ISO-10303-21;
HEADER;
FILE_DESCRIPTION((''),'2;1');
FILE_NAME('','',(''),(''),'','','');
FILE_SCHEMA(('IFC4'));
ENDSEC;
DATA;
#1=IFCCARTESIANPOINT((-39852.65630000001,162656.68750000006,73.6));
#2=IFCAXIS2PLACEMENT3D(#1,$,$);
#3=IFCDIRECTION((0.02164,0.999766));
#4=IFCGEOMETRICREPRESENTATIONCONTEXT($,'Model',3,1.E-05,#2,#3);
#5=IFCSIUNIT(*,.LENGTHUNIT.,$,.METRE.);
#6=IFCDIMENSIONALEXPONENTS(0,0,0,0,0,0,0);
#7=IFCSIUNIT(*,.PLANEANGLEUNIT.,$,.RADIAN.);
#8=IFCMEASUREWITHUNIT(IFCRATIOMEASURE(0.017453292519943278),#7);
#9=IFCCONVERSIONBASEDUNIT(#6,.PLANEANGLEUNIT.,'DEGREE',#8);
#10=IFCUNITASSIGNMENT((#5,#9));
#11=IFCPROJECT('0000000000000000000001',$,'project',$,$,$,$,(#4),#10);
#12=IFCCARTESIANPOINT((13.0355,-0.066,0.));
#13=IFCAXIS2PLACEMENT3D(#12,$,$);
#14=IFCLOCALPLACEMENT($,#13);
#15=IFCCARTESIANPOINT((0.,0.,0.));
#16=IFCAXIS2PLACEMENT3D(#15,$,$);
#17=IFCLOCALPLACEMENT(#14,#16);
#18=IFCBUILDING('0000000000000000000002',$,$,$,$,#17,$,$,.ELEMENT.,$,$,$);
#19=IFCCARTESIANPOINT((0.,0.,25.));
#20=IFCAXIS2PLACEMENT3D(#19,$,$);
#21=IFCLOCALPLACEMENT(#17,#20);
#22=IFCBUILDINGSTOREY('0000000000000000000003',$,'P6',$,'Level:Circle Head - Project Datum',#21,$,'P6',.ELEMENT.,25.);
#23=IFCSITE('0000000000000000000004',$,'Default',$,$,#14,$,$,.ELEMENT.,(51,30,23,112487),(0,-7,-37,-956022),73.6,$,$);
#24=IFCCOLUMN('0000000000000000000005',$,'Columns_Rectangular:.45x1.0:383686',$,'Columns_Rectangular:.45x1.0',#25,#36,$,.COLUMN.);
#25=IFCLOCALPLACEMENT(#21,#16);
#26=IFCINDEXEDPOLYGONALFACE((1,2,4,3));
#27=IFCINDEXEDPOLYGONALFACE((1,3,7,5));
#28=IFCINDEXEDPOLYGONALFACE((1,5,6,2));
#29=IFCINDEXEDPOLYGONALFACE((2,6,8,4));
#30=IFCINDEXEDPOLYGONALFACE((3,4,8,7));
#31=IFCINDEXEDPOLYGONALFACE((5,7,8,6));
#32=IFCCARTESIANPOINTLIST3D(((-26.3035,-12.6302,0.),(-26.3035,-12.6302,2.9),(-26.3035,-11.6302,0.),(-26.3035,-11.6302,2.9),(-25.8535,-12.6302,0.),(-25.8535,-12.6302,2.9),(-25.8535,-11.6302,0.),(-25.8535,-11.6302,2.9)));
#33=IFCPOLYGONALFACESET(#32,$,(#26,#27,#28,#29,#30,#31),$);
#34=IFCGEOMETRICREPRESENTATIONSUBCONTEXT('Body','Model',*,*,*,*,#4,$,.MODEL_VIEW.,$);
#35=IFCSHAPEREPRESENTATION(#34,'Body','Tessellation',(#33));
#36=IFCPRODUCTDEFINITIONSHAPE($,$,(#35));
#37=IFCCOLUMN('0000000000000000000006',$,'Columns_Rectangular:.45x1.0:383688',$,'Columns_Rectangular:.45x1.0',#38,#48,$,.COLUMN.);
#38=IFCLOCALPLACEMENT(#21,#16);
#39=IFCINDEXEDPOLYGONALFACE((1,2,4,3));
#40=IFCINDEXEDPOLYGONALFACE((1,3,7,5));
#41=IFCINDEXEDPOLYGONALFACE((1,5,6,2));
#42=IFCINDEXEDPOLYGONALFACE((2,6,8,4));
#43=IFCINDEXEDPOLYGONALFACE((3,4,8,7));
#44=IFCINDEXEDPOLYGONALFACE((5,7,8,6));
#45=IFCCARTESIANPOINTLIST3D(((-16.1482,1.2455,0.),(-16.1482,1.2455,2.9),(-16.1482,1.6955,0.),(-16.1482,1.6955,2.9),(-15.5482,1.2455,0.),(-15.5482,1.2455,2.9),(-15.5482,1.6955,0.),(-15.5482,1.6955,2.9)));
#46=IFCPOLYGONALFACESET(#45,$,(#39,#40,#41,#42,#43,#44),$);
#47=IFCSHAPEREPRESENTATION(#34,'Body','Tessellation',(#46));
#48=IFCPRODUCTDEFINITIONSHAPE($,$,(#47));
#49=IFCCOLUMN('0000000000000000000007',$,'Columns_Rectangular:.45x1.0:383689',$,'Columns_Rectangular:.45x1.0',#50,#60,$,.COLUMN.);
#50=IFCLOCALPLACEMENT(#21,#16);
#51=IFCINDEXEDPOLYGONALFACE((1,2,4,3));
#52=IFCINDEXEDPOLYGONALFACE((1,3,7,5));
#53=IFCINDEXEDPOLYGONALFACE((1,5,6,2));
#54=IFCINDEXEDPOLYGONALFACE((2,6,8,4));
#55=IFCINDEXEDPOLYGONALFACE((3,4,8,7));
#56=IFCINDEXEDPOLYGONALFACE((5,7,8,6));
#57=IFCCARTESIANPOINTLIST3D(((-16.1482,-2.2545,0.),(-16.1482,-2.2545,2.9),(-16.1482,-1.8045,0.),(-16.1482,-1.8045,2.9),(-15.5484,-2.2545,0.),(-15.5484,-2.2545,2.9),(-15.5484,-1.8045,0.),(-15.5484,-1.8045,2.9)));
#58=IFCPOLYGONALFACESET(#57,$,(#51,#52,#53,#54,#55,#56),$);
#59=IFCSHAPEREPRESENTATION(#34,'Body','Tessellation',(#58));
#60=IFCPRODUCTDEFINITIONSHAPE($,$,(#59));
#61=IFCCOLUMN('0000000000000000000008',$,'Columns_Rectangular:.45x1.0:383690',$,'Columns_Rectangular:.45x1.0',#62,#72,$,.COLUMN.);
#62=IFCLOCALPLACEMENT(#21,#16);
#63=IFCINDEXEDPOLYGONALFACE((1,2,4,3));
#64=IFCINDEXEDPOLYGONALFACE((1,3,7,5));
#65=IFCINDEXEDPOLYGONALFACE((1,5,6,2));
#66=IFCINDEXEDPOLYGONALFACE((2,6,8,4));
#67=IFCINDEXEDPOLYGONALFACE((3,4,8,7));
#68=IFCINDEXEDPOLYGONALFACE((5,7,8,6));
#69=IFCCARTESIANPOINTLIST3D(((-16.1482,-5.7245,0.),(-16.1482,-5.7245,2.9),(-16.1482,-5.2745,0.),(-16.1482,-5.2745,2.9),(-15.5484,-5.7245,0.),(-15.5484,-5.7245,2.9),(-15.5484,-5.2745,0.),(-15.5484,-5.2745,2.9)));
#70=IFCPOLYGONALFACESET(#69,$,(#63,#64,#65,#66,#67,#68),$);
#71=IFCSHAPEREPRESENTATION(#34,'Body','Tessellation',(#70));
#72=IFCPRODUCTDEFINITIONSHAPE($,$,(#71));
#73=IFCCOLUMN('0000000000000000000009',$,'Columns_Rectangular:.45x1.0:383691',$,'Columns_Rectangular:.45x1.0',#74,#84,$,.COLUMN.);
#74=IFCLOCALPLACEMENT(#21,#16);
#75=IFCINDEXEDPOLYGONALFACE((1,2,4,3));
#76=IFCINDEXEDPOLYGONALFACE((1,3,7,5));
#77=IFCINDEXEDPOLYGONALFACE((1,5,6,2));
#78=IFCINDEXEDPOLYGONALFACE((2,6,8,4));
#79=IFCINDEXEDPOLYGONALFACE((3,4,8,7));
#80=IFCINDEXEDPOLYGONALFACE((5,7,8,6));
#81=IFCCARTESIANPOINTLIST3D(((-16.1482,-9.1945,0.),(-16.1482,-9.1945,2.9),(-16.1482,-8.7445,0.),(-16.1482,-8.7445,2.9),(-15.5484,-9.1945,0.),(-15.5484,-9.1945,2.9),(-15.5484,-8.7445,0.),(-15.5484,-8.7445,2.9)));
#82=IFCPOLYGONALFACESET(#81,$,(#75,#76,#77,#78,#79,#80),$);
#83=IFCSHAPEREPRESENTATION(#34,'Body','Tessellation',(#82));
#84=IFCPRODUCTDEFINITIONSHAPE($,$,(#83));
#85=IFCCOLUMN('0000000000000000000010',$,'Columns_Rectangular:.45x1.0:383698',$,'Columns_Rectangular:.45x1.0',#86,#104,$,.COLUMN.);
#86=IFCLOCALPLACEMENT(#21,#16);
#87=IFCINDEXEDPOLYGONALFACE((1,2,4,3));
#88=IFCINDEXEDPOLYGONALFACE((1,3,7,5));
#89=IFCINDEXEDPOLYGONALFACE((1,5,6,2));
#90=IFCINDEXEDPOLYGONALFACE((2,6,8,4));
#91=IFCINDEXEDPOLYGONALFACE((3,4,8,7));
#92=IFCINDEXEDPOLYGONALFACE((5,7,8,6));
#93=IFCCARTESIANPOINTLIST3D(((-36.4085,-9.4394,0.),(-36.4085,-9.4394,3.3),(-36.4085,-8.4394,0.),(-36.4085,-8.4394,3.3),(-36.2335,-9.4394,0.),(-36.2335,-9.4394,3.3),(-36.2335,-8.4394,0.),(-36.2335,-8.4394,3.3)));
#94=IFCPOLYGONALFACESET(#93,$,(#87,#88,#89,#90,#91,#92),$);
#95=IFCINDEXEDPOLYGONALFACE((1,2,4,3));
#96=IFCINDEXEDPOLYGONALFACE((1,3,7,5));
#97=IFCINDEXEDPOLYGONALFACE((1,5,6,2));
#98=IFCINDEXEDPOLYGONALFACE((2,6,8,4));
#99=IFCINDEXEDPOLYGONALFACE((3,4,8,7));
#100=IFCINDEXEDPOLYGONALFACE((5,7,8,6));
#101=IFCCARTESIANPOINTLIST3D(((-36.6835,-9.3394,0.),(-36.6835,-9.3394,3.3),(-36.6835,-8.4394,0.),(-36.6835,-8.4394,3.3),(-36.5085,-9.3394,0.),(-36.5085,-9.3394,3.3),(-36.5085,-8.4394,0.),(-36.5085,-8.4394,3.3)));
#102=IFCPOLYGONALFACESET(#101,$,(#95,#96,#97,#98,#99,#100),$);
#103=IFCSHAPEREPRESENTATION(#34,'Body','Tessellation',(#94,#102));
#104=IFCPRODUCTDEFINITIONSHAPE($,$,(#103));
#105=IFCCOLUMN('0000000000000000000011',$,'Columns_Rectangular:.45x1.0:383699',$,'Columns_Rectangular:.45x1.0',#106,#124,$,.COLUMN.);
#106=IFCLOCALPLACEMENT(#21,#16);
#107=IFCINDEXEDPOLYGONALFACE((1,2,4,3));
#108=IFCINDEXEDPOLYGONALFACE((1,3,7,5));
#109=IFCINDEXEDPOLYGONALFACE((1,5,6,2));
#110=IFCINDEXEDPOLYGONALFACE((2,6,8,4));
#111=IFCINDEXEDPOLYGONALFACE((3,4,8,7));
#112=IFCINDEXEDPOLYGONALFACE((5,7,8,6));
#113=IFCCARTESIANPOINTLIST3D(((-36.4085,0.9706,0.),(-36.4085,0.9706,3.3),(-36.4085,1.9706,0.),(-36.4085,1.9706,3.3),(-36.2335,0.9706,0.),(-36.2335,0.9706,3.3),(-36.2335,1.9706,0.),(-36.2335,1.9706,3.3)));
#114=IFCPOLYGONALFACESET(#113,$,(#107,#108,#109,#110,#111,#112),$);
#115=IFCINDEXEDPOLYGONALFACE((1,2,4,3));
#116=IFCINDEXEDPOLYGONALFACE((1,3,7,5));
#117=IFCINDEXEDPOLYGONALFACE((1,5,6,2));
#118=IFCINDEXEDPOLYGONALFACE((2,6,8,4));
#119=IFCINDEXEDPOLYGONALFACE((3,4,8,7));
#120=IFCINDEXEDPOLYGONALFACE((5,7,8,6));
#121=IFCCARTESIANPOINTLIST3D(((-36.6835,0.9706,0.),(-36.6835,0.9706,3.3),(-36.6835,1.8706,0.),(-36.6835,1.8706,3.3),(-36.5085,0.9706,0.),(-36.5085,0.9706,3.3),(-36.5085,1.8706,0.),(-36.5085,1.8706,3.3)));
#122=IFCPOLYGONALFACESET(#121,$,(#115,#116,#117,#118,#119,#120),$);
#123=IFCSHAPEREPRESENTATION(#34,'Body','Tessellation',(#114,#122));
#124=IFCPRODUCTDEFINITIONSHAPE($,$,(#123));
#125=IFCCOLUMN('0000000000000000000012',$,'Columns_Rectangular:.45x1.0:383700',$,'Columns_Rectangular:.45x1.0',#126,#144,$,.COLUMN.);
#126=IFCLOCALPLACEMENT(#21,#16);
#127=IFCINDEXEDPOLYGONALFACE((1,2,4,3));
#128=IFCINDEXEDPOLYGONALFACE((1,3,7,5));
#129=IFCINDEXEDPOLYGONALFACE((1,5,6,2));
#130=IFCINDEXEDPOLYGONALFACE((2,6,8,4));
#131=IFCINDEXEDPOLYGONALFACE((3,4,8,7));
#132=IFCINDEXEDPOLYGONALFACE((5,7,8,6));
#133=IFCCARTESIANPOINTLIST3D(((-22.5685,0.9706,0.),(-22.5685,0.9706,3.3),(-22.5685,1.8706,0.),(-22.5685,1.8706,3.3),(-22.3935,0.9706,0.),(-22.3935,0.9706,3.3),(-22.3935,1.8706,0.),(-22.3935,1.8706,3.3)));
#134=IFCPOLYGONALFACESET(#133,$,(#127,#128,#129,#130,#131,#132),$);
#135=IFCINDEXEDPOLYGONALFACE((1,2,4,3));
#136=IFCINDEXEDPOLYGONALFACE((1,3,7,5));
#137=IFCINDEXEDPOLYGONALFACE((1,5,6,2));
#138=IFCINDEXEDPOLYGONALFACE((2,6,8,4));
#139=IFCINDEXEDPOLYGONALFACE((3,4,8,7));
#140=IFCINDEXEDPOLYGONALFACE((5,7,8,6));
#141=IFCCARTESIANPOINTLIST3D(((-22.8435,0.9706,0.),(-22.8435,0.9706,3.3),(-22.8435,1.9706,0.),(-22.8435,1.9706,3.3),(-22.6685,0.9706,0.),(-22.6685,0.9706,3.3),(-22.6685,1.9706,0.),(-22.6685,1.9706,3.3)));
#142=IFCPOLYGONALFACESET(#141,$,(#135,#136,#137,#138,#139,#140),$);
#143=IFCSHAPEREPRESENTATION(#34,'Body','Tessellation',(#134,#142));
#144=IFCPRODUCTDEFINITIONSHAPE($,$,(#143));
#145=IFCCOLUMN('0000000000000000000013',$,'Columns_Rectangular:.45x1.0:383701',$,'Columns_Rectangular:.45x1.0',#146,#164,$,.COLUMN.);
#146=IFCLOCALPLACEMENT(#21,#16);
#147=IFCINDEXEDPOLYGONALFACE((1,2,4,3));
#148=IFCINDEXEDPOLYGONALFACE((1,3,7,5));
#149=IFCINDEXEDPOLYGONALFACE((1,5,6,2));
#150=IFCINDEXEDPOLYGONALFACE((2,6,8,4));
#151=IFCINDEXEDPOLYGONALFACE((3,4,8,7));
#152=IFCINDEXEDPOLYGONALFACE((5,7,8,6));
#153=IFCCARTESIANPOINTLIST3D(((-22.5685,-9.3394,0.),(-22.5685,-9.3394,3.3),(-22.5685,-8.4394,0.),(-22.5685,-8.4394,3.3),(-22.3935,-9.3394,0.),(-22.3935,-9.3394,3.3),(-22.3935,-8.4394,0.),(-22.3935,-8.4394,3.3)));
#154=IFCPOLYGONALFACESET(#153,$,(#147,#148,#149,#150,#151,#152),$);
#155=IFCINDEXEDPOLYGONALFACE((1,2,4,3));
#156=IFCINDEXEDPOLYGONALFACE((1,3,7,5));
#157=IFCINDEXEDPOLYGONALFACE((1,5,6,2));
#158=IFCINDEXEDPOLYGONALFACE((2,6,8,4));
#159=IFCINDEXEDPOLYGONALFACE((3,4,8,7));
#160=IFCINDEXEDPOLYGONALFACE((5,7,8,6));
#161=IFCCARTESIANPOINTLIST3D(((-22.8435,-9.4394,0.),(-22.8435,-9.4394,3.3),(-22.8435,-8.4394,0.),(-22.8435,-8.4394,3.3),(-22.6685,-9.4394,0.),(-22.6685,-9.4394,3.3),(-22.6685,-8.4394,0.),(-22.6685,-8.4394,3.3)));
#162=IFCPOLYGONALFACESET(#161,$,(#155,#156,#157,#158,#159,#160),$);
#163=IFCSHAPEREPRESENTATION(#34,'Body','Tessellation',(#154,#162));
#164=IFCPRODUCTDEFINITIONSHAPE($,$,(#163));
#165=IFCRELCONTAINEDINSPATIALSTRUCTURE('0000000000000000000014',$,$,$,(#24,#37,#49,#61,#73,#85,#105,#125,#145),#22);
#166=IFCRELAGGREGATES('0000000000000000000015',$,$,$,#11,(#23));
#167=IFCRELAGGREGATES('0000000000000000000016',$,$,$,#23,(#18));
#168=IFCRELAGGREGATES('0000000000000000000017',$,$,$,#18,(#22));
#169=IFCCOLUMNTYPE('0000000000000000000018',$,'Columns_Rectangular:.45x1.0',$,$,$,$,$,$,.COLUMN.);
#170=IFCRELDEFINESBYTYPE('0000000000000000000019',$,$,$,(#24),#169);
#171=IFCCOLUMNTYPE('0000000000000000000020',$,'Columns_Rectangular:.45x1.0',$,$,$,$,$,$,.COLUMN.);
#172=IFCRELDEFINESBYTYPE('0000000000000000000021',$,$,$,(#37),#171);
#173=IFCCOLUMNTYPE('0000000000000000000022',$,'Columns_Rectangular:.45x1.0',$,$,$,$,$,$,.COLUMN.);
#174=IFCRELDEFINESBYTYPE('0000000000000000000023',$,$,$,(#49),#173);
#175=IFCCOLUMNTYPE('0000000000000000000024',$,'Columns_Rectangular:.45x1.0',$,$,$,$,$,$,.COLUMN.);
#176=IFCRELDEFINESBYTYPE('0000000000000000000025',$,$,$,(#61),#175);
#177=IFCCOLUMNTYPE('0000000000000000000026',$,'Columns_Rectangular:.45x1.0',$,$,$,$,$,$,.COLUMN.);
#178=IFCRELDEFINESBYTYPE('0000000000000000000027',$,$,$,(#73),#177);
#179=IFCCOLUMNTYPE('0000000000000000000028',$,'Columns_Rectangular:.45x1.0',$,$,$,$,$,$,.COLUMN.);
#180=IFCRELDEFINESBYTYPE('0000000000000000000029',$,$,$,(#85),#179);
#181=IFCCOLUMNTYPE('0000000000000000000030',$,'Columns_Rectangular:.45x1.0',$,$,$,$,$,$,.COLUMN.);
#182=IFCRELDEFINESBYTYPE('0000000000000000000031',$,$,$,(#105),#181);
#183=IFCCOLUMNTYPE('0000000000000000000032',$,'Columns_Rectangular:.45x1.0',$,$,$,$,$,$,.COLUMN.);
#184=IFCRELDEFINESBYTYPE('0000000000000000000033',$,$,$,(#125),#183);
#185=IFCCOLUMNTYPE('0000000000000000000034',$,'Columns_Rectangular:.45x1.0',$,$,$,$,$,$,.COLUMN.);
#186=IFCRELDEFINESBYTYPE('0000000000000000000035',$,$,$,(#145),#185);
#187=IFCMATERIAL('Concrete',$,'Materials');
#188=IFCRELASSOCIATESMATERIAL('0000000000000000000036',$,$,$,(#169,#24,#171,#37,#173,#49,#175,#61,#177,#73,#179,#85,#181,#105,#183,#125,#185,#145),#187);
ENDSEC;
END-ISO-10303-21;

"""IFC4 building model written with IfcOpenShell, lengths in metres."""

from ifc_helpers import new_model, entity, si_unit, converted_unit, direction, frame, origin, place, context, subcontext, project, spatial, indexed_curve, outline, extrude, source, transform, mapped, material, type_object, type_shapes, element, save


model = new_model("IFC4")

# Units and contexts
model_context = context("Model", 3, precision=1e-05, world=frame((-39852.65630000001, 162656.68750000006, 73.6)), true_north=direction((0.02164, 0.999766)))
body_context = subcontext(model_context, "Body", "Model", "MODEL_VIEW")
ifc_project = project(units=[si_unit("LENGTHUNIT", "METRE"), converted_unit("PLANEANGLEUNIT", "DEGREE", entity("IfcRatioMeasure", 0.017453292519943278), si_unit("PLANEANGLEUNIT", "RADIAN"), dimensions=[0, 0, 0, 0, 0, 0, 0])], contexts=[model_context])

# Site, building, storey
site_placement = place(None, frame((13.0355, -0.066, 0.0)))
site = spatial("IfcSite", under=ifc_project, at=site_placement, Name="Default", CompositionType="ELEMENT", RefLatitude=(51, 30, 23, 112487), RefLongitude=(0, -7, -37, -956022), RefElevation=73.6)
building_placement = place(site_placement, origin())
building = spatial("IfcBuilding", under=site, at=building_placement, CompositionType="ELEMENT")
storey_placement = place(building_placement, frame((0.0, 0.0, 25.0)))
storey = spatial("IfcBuildingStorey", under=building, at=storey_placement, Name="P6", ObjectType="Level:Circle Head - Project Datum", LongName="P6", CompositionType="ELEMENT", Elevation=25.0)

# Columns
ifc_material = material(Name="Concrete", Category="Materials")
column_type_1 = type_object("IfcColumnType", Name="Columns_Rectangular:.45x1.0", PredefinedType="COLUMN", material=ifc_material)
shared_shape_1 = source(origin(), body_context, "Body", "SweptSolid", [
    extrude(outline(indexed_curve([(-0.5, -0.225), (0.5, -0.225), (0.5, 0.225), (-0.5, 0.225), (-0.5, -0.225)], self_intersect=False)), frame((-26.0785, -12.1302, 25.0), z_axis=(0.0, 0.0, 1.0), x_axis=(0.000011, 1.0, 0.0)), (0.0, 0.0, 1.0), 2.9),
])
type_shapes(column_type_1, [shared_shape_1])
column_1_placement = place(storey_placement, frame((0.0, 0.0, -25.0)))
element("IfcColumn", 1, at=column_1_placement, inside=storey, type_object=column_type_1, material=ifc_material, Name="Columns_Rectangular:.45x1.0:383686", ObjectType="Columns_Rectangular:.45x1.0", PredefinedType="COLUMN", context=body_context, shape_type="MappedRepresentation", body=[
    mapped(shared_shape_1, transform((0.0, 0.0, 0.0), scale=1.0)),
])
column_type_2 = type_object("IfcColumnType", Name="Columns_Rectangular:.45x1.0", PredefinedType="COLUMN", material=ifc_material)
shared_shape_2 = source(origin(), body_context, "Body", "SweptSolid", [
    extrude(outline(indexed_curve([(-0.225, -0.3), (0.225, -0.3), (0.225, 0.3), (-0.225, 0.3), (-0.225, -0.3)], self_intersect=False)), frame((-15.8482, 1.4705, 25.0), z_axis=(0.0, 0.0, 1.0), x_axis=(0.0, -1.0, 0.0)), (0.0, 0.0, 1.0), 2.9),
])
type_shapes(column_type_2, [shared_shape_2])
column_2_placement = place(storey_placement, frame((0.0, 0.0, -25.0)))
element("IfcColumn", 2, at=column_2_placement, inside=storey, type_object=column_type_2, material=ifc_material, Name="Columns_Rectangular:.45x1.0:383688", ObjectType="Columns_Rectangular:.45x1.0", PredefinedType="COLUMN", context=body_context, shape_type="MappedRepresentation", body=[
    mapped(shared_shape_2, transform((0.0, 0.0, 0.0), scale=1.0)),
])
column_type_3 = type_object("IfcColumnType", Name="Columns_Rectangular:.45x1.0", PredefinedType="COLUMN", material=ifc_material)
shared_shape_3 = source(origin(), body_context, "Body", "SweptSolid", [
    extrude(outline(indexed_curve([(-0.225, -0.2999), (0.225, -0.2999), (0.225, 0.2999), (-0.225, 0.2999), (-0.225, -0.2999)], self_intersect=False)), frame((-15.8483, -2.0295, 25.0), z_axis=(0.0, 0.0, 1.0), x_axis=(0.0, -1.0, 0.0)), (0.0, 0.0, 1.0), 2.9),
])
type_shapes(column_type_3, [shared_shape_3])
column_3_placement = place(storey_placement, frame((0.0, 0.0, -25.0)))
element("IfcColumn", 3, at=column_3_placement, inside=storey, type_object=column_type_3, material=ifc_material, Name="Columns_Rectangular:.45x1.0:383689", ObjectType="Columns_Rectangular:.45x1.0", PredefinedType="COLUMN", context=body_context, shape_type="MappedRepresentation", body=[
    mapped(shared_shape_3, transform((0.0, 0.0, 0.0), scale=1.0)),
])
column_type_4 = type_object("IfcColumnType", Name="Columns_Rectangular:.45x1.0", PredefinedType="COLUMN", material=ifc_material)
shared_shape_4 = source(origin(), body_context, "Body", "SweptSolid", [
    extrude(outline(indexed_curve([(-0.225, -0.2999), (0.225, -0.2999), (0.225, 0.2999), (-0.225, 0.2999), (-0.225, -0.2999)], self_intersect=False)), frame((-15.8483, -5.4995, 25.0), z_axis=(0.0, 0.0, 1.0), x_axis=(0.0, -1.0, 0.0)), (0.0, 0.0, 1.0), 2.9),
])
type_shapes(column_type_4, [shared_shape_4])
column_4_placement = place(storey_placement, frame((0.0, 0.0, -25.0)))
element("IfcColumn", 4, at=column_4_placement, inside=storey, type_object=column_type_4, material=ifc_material, Name="Columns_Rectangular:.45x1.0:383690", ObjectType="Columns_Rectangular:.45x1.0", PredefinedType="COLUMN", context=body_context, shape_type="MappedRepresentation", body=[
    mapped(shared_shape_4, transform((0.0, 0.0, 0.0), scale=1.0)),
])
column_type_5 = type_object("IfcColumnType", Name="Columns_Rectangular:.45x1.0", PredefinedType="COLUMN", material=ifc_material)
shared_shape_5 = source(origin(), body_context, "Body", "SweptSolid", [
    extrude(outline(indexed_curve([(-0.225, -0.2999), (0.225, -0.2999), (0.225, 0.2999), (-0.225, 0.2999), (-0.225, -0.2999)], self_intersect=False)), frame((-15.8483, -8.9695, 25.0), z_axis=(0.0, 0.0, 1.0), x_axis=(0.0, -1.0, 0.0)), (0.0, 0.0, 1.0), 2.9),
])
type_shapes(column_type_5, [shared_shape_5])
column_5_placement = place(storey_placement, frame((0.0, 0.0, -25.0)))
element("IfcColumn", 5, at=column_5_placement, inside=storey, type_object=column_type_5, material=ifc_material, Name="Columns_Rectangular:.45x1.0:383691", ObjectType="Columns_Rectangular:.45x1.0", PredefinedType="COLUMN", context=body_context, shape_type="MappedRepresentation", body=[
    mapped(shared_shape_5, transform((0.0, 0.0, 0.0), scale=1.0)),
])
column_type_6 = type_object("IfcColumnType", Name="Columns_Rectangular:.45x1.0", PredefinedType="COLUMN", material=ifc_material)
shared_shape_6 = source(origin(), body_context, "Body", "SweptSolid", [
    extrude(outline(indexed_curve([(-0.5, -0.0875), (0.5, -0.0875), (0.5, 0.0875), (-0.5, 0.0875), (-0.5, -0.0875)], self_intersect=False)), frame((-36.321, -8.9394, 25.0), z_axis=(0.0, 0.0, 1.0), x_axis=(0.0, -1.0, 0.0)), (0.0, 0.0, 1.0), 3.3),
    extrude(outline(indexed_curve([(-0.45, -0.0875), (0.45, -0.0875), (0.45, 0.0875), (-0.45, 0.0875), (-0.45, -0.0875)], self_intersect=False)), frame((-36.596, -8.8894, 25.0), z_axis=(0.0, 0.0, 1.0), x_axis=(0.0, -1.0, 0.0)), (0.0, 0.0, 1.0), 3.3),
])
type_shapes(column_type_6, [shared_shape_6])
column_6_placement = place(storey_placement, frame((0.0, 0.0, -25.0)))
element("IfcColumn", 6, at=column_6_placement, inside=storey, type_object=column_type_6, material=ifc_material, Name="Columns_Rectangular:.45x1.0:383698", ObjectType="Columns_Rectangular:.45x1.0", PredefinedType="COLUMN", context=body_context, shape_type="MappedRepresentation", body=[
    mapped(shared_shape_6, transform((0.0, 0.0, 0.0), scale=1.0)),
])
column_type_7 = type_object("IfcColumnType", Name="Columns_Rectangular:.45x1.0", PredefinedType="COLUMN", material=ifc_material)
shared_shape_7 = source(origin(), body_context, "Body", "SweptSolid", [
    extrude(outline(indexed_curve([(-0.5, -0.0875), (0.5, -0.0875), (0.5, 0.0875), (-0.5, 0.0875), (-0.5, -0.0875)], self_intersect=False)), frame((-36.321, 1.4706, 25.0), z_axis=(0.0, 0.0, 1.0), x_axis=(0.0, -1.0, 0.0)), (0.0, 0.0, 1.0), 3.3),
    extrude(outline(indexed_curve([(-0.45, -0.0875), (0.45, -0.0875), (0.45, 0.0875), (-0.45, 0.0875), (-0.45, -0.0875)], self_intersect=False)), frame((-36.596, 1.4206, 25.0), z_axis=(0.0, 0.0, 1.0), x_axis=(0.0, -1.0, 0.0)), (0.0, 0.0, 1.0), 3.3),
])
type_shapes(column_type_7, [shared_shape_7])
column_7_placement = place(storey_placement, frame((0.0, 0.0, -25.0)))
element("IfcColumn", 7, at=column_7_placement, inside=storey, type_object=column_type_7, material=ifc_material, Name="Columns_Rectangular:.45x1.0:383699", ObjectType="Columns_Rectangular:.45x1.0", PredefinedType="COLUMN", context=body_context, shape_type="MappedRepresentation", body=[
    mapped(shared_shape_7, transform((0.0, 0.0, 0.0), scale=1.0)),
])
column_type_8 = type_object("IfcColumnType", Name="Columns_Rectangular:.45x1.0", PredefinedType="COLUMN", material=ifc_material)
shared_shape_8 = source(origin(), body_context, "Body", "SweptSolid", [
    extrude(outline(indexed_curve([(-0.45, -0.0875), (0.45, -0.0875), (0.45, 0.0875), (-0.45, 0.0875), (-0.45, -0.0875)], self_intersect=False)), frame((-22.481, 1.4206, 25.0), z_axis=(0.0, 0.0, 1.0), x_axis=(0.0, -1.0, 0.0)), (0.0, 0.0, 1.0), 3.3),
    extrude(outline(indexed_curve([(-0.5, -0.0875), (0.5, -0.0875), (0.5, 0.0875), (-0.5, 0.0875), (-0.5, -0.0875)], self_intersect=False)), frame((-22.756, 1.4706, 25.0), z_axis=(0.0, 0.0, 1.0), x_axis=(0.0, -1.0, 0.0)), (0.0, 0.0, 1.0), 3.3),
])
type_shapes(column_type_8, [shared_shape_8])
column_8_placement = place(storey_placement, frame((0.0, 0.0, -25.0)))
element("IfcColumn", 8, at=column_8_placement, inside=storey, type_object=column_type_8, material=ifc_material, Name="Columns_Rectangular:.45x1.0:383700", ObjectType="Columns_Rectangular:.45x1.0", PredefinedType="COLUMN", context=body_context, shape_type="MappedRepresentation", body=[
    mapped(shared_shape_8, transform((0.0, 0.0, 0.0), scale=1.0)),
])
column_type_9 = type_object("IfcColumnType", Name="Columns_Rectangular:.45x1.0", PredefinedType="COLUMN", material=ifc_material)
shared_shape_9 = source(origin(), body_context, "Body", "SweptSolid", [
    extrude(outline(indexed_curve([(-0.45, -0.0875), (0.45, -0.0875), (0.45, 0.0875), (-0.45, 0.0875), (-0.45, -0.0875)], self_intersect=False)), frame((-22.481, -8.8894, 25.0), z_axis=(0.0, 0.0, 1.0), x_axis=(0.0, -1.0, 0.0)), (0.0, 0.0, 1.0), 3.3),
    extrude(outline(indexed_curve([(-0.5, -0.0875), (0.5, -0.0875), (0.5, 0.0875), (-0.5, 0.0875), (-0.5, -0.0875)], self_intersect=False)), frame((-22.756, -8.9394, 25.0), z_axis=(0.0, 0.0, 1.0), x_axis=(0.0, -1.0, 0.0)), (0.0, 0.0, 1.0), 3.3),
])
type_shapes(column_type_9, [shared_shape_9])
column_9_placement = place(storey_placement, frame((0.0, 0.0, -25.0)))
element("IfcColumn", 9, at=column_9_placement, inside=storey, type_object=column_type_9, material=ifc_material, Name="Columns_Rectangular:.45x1.0:383701", ObjectType="Columns_Rectangular:.45x1.0", PredefinedType="COLUMN", context=body_context, shape_type="MappedRepresentation", body=[
    mapped(shared_shape_9, transform((0.0, 0.0, 0.0), scale=1.0)),
])

save(model, "model.ifc")
